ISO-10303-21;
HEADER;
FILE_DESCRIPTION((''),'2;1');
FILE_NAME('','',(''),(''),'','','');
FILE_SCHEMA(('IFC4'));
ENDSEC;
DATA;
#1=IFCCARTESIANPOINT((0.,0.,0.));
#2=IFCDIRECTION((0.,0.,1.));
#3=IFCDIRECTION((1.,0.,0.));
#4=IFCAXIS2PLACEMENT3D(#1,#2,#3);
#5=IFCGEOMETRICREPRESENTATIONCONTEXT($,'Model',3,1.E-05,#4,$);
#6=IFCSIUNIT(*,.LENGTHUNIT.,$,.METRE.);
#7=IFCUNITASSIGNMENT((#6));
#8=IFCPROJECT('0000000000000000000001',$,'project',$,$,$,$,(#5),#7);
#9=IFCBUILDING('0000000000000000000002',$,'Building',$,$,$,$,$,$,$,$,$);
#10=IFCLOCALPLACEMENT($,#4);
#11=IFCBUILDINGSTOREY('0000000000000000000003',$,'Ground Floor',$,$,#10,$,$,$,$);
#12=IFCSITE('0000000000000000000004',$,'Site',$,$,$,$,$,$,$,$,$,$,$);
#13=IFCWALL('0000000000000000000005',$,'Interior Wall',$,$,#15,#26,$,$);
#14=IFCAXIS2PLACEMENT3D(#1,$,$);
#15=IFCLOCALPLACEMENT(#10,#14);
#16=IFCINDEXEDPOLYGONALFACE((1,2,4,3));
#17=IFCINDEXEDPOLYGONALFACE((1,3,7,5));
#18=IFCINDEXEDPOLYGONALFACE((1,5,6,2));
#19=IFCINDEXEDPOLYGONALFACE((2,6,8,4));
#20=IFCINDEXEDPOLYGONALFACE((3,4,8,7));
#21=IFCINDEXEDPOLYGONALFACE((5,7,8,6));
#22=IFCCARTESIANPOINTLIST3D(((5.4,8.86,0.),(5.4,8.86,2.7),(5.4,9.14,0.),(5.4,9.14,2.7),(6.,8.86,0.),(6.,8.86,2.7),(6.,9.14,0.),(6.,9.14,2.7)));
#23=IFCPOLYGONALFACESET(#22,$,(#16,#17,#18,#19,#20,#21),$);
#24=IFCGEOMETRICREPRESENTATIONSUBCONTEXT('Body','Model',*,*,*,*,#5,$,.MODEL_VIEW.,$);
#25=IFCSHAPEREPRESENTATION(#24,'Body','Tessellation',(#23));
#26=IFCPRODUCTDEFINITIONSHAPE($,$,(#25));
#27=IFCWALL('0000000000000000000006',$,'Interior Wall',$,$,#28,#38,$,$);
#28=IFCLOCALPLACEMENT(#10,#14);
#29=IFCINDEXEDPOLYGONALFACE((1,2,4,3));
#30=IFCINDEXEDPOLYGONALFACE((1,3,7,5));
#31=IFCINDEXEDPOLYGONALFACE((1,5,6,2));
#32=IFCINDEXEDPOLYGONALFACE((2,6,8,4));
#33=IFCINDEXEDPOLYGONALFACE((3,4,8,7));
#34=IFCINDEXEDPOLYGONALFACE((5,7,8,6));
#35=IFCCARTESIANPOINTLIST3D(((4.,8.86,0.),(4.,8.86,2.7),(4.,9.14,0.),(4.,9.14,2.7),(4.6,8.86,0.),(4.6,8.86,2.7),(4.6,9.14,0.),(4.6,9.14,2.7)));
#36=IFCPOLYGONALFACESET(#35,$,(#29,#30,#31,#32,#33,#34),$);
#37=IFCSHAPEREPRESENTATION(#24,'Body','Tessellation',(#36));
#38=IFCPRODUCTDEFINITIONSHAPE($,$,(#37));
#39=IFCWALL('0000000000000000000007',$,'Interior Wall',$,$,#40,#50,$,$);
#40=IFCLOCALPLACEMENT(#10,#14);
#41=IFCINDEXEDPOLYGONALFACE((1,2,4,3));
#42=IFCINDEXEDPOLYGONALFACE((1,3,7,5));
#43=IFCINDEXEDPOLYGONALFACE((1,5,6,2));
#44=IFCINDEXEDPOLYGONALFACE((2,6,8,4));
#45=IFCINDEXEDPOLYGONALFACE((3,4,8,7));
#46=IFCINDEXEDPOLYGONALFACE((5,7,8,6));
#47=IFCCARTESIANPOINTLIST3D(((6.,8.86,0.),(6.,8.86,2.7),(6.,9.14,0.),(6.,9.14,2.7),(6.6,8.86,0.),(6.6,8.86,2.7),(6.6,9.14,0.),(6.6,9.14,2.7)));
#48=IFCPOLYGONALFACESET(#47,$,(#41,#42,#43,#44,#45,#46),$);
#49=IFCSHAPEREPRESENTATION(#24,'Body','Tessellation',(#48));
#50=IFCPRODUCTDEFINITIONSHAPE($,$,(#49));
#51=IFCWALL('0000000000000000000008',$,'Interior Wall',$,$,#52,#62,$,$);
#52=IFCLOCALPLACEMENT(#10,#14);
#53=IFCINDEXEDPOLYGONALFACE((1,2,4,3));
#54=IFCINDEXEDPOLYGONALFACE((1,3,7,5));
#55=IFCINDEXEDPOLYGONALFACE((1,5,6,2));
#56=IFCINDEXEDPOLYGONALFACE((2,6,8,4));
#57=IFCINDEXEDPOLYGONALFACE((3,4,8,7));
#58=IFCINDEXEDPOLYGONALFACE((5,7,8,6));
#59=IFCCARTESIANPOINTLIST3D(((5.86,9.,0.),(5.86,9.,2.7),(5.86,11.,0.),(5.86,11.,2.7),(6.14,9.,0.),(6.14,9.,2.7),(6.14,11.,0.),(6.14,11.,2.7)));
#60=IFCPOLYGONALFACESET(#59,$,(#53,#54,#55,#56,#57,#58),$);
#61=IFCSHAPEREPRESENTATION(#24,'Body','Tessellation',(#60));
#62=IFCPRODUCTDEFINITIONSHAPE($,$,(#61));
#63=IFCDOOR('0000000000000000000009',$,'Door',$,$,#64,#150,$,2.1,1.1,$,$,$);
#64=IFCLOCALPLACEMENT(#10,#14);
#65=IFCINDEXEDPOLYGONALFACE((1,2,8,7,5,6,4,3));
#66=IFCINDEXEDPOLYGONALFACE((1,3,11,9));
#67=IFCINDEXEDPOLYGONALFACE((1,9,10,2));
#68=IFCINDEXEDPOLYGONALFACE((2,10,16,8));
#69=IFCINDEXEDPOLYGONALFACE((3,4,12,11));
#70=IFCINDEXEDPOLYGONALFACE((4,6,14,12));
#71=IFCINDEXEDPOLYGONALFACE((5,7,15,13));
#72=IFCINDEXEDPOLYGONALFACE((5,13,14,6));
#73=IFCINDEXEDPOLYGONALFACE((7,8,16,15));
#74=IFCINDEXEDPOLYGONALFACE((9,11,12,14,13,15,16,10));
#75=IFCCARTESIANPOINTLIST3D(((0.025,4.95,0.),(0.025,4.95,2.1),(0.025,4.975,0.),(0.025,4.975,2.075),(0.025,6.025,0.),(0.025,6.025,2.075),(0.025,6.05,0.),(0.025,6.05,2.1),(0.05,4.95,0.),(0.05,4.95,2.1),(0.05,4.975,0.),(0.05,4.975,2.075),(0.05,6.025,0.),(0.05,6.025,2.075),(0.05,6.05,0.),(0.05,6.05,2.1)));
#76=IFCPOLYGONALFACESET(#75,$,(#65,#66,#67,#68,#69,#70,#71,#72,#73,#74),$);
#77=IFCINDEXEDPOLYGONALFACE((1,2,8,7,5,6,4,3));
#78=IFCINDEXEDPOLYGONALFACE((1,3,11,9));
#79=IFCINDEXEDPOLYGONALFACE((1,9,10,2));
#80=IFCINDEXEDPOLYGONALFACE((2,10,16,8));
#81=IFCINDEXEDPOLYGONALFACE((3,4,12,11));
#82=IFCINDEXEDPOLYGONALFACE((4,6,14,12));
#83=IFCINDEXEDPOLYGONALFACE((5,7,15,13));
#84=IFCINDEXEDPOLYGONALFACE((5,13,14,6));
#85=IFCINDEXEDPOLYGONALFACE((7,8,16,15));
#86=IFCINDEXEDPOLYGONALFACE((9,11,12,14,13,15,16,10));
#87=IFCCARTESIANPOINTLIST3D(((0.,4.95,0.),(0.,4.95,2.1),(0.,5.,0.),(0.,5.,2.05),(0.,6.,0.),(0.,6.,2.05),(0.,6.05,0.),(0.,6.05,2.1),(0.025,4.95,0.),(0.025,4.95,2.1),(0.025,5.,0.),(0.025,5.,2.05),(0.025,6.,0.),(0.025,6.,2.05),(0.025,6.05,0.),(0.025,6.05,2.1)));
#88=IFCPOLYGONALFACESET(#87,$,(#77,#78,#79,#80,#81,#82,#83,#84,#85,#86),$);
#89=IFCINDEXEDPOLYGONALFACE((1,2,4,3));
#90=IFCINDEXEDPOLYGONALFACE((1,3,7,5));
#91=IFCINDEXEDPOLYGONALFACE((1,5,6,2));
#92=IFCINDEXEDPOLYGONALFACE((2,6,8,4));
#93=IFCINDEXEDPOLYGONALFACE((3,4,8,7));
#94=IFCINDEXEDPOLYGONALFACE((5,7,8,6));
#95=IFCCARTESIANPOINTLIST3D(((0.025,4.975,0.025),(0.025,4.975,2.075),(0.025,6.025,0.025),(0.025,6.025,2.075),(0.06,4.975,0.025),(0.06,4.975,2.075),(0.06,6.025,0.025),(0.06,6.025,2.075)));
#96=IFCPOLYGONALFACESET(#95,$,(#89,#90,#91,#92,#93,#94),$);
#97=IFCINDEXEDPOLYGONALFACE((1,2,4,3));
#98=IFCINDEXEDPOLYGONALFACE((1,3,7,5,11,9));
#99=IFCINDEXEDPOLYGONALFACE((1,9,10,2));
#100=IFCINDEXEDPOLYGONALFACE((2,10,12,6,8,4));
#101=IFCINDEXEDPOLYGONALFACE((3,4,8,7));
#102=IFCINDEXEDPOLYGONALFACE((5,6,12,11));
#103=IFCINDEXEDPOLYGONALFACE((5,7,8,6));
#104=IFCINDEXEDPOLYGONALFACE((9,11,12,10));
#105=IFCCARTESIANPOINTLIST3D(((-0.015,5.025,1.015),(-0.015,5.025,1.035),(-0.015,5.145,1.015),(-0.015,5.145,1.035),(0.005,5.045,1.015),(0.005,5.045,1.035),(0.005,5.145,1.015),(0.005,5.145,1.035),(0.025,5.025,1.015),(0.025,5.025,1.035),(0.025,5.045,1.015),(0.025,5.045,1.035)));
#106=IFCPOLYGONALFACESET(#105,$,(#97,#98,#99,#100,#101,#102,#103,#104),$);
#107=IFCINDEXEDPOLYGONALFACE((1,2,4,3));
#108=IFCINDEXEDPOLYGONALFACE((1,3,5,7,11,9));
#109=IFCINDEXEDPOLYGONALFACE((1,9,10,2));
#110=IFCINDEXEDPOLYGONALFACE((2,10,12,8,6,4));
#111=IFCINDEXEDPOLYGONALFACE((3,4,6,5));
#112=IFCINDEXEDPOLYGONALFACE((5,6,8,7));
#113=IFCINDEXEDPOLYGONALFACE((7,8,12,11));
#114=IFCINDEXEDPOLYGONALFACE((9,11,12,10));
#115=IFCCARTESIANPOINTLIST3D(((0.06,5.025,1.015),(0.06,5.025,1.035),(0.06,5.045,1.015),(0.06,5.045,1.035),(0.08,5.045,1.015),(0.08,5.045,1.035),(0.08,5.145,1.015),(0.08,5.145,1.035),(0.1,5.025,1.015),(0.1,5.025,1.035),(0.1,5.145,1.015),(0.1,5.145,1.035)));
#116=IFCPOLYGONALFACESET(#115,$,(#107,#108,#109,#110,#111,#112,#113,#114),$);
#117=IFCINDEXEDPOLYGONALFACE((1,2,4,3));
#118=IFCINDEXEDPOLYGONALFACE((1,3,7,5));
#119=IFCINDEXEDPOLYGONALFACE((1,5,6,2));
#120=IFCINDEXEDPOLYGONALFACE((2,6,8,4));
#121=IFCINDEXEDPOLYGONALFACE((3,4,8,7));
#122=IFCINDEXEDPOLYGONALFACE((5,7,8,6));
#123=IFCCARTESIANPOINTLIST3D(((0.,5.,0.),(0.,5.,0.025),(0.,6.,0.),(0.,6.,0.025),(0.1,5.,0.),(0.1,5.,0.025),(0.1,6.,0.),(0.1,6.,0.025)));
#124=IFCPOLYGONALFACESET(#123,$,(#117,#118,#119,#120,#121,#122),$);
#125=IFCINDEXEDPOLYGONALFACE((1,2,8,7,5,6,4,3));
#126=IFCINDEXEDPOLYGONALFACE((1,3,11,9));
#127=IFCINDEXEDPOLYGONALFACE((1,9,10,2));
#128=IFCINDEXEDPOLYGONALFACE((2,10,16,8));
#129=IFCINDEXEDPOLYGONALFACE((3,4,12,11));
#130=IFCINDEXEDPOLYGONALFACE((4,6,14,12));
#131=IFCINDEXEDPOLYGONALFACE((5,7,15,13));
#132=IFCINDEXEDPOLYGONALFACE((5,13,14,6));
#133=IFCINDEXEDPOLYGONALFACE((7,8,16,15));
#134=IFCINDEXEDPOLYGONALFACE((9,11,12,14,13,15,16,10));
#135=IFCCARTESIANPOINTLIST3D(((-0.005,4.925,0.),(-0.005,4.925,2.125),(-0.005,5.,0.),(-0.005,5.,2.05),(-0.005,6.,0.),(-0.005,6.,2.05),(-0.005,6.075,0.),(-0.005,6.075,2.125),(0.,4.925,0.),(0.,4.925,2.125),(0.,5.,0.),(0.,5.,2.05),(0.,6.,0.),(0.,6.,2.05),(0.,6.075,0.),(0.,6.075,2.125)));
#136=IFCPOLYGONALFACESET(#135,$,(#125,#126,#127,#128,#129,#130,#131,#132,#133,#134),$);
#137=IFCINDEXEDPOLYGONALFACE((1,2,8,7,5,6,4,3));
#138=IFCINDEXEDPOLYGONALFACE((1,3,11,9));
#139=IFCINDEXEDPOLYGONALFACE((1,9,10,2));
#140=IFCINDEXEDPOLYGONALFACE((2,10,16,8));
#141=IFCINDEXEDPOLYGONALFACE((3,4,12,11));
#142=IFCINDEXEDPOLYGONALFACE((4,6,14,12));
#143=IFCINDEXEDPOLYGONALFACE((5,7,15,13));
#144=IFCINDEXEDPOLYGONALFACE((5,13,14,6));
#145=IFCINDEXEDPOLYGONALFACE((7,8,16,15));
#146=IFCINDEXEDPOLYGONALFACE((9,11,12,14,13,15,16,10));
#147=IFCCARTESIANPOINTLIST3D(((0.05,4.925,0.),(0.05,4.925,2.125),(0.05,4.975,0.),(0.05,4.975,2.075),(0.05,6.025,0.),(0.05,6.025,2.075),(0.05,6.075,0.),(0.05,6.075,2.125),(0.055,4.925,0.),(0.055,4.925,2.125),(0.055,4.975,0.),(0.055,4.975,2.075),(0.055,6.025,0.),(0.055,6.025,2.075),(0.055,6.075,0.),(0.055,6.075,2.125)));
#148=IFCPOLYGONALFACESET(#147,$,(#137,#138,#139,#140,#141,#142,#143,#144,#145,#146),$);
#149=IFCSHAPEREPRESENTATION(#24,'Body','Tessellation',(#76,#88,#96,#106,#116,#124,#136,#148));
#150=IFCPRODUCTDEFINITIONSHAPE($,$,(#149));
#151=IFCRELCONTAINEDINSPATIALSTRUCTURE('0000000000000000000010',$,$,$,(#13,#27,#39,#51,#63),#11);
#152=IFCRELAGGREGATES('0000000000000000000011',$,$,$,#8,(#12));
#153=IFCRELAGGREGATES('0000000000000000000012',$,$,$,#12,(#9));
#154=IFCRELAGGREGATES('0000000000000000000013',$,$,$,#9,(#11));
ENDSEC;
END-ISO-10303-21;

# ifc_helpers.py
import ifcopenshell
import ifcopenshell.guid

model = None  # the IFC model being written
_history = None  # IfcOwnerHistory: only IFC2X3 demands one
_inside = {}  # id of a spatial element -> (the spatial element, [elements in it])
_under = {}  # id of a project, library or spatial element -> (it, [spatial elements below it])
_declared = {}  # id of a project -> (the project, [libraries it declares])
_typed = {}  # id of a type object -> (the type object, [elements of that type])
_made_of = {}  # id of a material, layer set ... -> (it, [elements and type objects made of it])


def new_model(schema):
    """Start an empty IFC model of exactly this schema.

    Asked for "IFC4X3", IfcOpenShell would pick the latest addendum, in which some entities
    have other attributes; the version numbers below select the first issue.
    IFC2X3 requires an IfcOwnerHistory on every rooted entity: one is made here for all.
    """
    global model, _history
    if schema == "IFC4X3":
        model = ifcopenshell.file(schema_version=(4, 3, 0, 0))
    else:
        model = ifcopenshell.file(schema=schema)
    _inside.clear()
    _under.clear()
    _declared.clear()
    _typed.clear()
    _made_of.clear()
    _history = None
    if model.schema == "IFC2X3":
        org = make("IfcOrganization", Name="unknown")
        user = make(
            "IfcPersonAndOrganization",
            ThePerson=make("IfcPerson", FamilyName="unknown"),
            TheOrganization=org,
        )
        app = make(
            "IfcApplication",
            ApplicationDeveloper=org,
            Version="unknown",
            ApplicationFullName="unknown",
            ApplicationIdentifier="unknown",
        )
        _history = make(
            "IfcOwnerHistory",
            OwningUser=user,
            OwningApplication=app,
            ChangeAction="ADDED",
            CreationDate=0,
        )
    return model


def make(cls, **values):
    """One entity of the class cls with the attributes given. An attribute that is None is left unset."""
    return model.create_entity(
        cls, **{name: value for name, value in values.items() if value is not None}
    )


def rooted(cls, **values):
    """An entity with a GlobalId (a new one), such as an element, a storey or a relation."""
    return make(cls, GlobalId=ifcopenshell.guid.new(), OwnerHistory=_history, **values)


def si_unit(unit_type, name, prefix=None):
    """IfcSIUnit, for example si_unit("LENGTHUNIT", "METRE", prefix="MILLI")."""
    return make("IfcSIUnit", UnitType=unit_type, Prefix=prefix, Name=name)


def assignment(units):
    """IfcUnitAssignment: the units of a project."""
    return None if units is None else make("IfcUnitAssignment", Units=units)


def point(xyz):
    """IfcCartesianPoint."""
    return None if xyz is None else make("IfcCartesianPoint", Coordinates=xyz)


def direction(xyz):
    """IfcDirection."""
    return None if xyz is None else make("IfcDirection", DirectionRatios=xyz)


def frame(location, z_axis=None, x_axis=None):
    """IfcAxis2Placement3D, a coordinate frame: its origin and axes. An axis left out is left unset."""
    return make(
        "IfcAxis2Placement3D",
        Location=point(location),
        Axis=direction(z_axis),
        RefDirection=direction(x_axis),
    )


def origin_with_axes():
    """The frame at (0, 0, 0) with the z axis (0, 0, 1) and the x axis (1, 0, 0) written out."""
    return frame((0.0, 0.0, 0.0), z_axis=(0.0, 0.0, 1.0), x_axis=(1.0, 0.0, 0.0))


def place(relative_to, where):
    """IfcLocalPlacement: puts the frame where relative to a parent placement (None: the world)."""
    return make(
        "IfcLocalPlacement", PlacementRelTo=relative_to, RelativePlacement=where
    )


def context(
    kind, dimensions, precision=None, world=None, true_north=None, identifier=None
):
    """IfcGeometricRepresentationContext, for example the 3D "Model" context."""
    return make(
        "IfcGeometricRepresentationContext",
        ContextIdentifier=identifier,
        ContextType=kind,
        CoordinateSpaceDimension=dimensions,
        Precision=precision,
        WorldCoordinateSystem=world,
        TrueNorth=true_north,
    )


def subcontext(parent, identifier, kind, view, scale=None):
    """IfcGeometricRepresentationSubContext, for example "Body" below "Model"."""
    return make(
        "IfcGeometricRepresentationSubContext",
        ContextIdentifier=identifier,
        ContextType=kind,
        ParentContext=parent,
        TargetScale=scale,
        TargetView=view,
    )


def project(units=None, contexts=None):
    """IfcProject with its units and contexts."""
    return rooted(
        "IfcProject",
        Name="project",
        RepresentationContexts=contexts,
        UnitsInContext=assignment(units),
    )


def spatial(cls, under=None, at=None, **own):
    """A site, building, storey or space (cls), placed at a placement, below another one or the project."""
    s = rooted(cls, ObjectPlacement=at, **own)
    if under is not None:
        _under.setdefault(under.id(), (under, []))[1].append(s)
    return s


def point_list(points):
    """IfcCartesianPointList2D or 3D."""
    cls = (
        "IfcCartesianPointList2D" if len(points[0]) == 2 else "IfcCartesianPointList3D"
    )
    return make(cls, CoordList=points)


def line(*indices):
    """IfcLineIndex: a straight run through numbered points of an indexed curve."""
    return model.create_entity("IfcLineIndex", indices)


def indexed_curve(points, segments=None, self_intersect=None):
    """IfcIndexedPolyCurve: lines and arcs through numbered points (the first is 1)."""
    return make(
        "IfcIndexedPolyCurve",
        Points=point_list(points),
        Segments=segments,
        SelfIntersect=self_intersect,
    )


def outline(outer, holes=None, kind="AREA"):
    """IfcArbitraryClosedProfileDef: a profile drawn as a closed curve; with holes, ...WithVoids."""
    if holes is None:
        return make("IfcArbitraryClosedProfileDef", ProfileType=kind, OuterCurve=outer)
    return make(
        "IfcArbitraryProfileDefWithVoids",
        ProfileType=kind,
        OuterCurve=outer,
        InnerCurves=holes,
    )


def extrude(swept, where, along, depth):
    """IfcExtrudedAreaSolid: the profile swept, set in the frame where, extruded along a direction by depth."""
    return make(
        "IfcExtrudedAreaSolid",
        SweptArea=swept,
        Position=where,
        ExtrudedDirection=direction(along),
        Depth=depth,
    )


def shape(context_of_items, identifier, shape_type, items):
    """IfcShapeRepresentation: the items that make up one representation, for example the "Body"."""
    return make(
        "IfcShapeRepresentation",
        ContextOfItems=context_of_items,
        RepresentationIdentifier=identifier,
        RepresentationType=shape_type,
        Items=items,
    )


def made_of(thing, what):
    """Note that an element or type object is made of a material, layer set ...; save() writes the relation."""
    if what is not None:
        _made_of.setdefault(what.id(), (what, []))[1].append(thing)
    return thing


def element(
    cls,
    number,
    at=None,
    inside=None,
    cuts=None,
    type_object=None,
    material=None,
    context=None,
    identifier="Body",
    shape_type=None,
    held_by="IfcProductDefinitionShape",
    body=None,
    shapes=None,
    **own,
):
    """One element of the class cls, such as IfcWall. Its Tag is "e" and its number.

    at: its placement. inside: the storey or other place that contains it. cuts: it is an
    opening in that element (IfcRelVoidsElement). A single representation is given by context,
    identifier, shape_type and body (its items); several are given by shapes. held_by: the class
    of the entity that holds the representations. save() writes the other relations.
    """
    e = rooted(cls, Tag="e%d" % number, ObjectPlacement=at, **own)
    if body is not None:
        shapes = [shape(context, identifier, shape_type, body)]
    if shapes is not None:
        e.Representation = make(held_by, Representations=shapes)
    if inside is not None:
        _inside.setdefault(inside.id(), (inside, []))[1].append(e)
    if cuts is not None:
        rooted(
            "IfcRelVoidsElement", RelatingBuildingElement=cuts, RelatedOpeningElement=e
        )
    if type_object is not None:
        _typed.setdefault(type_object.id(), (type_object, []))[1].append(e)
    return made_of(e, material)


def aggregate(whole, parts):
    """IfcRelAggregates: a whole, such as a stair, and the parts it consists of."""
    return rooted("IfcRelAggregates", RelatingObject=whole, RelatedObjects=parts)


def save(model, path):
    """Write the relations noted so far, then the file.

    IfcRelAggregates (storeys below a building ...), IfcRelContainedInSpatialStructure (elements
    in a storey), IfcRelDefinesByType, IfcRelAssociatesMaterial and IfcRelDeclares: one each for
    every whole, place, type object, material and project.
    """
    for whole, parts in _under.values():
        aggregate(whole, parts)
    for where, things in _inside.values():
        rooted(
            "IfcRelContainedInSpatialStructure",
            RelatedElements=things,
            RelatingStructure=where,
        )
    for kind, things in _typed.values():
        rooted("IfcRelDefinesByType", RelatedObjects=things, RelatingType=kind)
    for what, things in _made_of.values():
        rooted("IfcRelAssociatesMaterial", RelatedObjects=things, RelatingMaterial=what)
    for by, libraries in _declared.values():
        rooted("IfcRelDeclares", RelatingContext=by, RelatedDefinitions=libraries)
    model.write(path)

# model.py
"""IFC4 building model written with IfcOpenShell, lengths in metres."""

from ifc_helpers import new_model, si_unit, frame, origin_with_axes, place, context, subcontext, project, spatial, line, indexed_curve, outline, extrude, element, save


model = new_model("IFC4")

# Units and contexts
model_context = context("Model", 3, precision=1e-05, world=origin_with_axes())
body_context = subcontext(model_context, "Body", "Model", "MODEL_VIEW")
ifc_project = project(units=[si_unit("LENGTHUNIT", "METRE")], contexts=[model_context])

# Site, building, storey
site = spatial("IfcSite", under=ifc_project, Name="Site")
building = spatial("IfcBuilding", under=site, Name="Building")
storey_placement = place(None, origin_with_axes())
storey = spatial("IfcBuildingStorey", under=building, at=storey_placement, Name="Ground Floor")

# Walls
for number, where, z_axis, x_axis, name in (
    (1, (6.0, 9.0, 0.0), (0.0, 0.0, 1.0), (-1.0, 0.0, 0.0), "Interior Wall"),
    (2, (4.6, 9.0, 0.0), (0.0, 0.0, 1.0), (-1.0, 0.0, 0.0), "Interior Wall"),
    (3, (6.6, 9.0, 0.0), (0.0, 0.0, 1.0), (-1.0, 0.0, 0.0), "Interior Wall"),
):
    element("IfcWall", number, at=place(storey_placement, frame(where, z_axis=z_axis, x_axis=x_axis)), inside=storey, Name=name, context=body_context, shape_type="SweptSolid", body=[
        extrude(outline(indexed_curve([(0.0, 0.0), (0.0, 0.28), (0.6, 0.28), (0.6, 0.0), (0.0, 0.0)], self_intersect=False)), frame((0.0, -0.14, 0.0), z_axis=(0.0, 0.0, 1.0), x_axis=(1.0, 0.0, 0.0)), (0.0, 0.0, 1.0), 2.7),
    ])
wall_1_placement = place(storey_placement, frame((6.0, 9.0, 0.0), z_axis=(0.0, 0.0, 1.0), x_axis=(0.0, 1.0, 0.0)))
element("IfcWall", 4, at=wall_1_placement, inside=storey, Name="Interior Wall", context=body_context, shape_type="SweptSolid", body=[
    extrude(outline(indexed_curve([(0.0, 0.0), (0.0, 0.28), (2.0, 0.28), (2.0, 0.0), (0.0, 0.0)], self_intersect=False)), frame((0.0, -0.14, 0.0), z_axis=(0.0, 0.0, 1.0), x_axis=(1.0, 0.0, 0.0)), (0.0, 0.0, 1.0), 2.7),
])

# Door
door_1_placement = place(storey_placement, frame((0.0, 6.05, 0.0), z_axis=(0.0, 0.0, 1.0), x_axis=(0.0, -1.0, 0.0)))
element("IfcDoor", 5, at=door_1_placement, inside=storey, Name="Door", OverallHeight=2.1, OverallWidth=1.1, context=body_context, shape_type="SweptSolid", body=[
    extrude(outline(indexed_curve([(0.0, 0.0), (0.0, 2.1), (1.1, 2.1), (1.1, 0.0), (1.075, 0.0), (1.075, 2.075), (0.025, 2.075), (0.025, 0.0)], segments=[line(1, 2, 3, 4, 5, 6, 7, 8, 1)])), frame((0.0, 0.025, 0.0), z_axis=(0.0, -1.0, 0.0), x_axis=(1.0, 0.0, 0.0)), (0.0, 0.0, -1.0), 0.025),
    extrude(outline(indexed_curve([(0.0, 0.0), (0.0, 2.1), (1.1, 2.1), (1.1, 0.0), (1.05, 0.0), (1.05, 2.05), (0.05, 2.05), (0.05, 0.0)], segments=[line(1, 2, 3, 4, 5, 6, 7, 8, 1)])), frame((0.0, 0.0, 0.0), z_axis=(0.0, -1.0, 0.0), x_axis=(1.0, 0.0, 0.0)), (0.0, 0.0, -1.0), 0.025),
    extrude(outline(indexed_curve([(0.0, 0.0), (1.05, 0.0), (1.05, 0.035), (0.0, 0.035)], segments=[line(1, 2, 3, 4, 1)])), frame((0.025, 0.025, 0.025), z_axis=(0.0, 0.0, 1.0), x_axis=(1.0, 0.0, 0.0)), (0.0, 0.0, 1.0), 2.05),
    extrude(outline(indexed_curve([(0.0, 0.0), (0.0, -0.04), (-0.12, -0.04), (-0.12, -0.02), (-0.02, -0.02), (-0.02, 0.0)], segments=[line(1, 2, 3, 4, 5, 6, 1)])), frame((1.025, 0.025, 1.015), z_axis=(0.0, 0.0, 1.0), x_axis=(1.0, 0.0, 0.0)), (0.0, 0.0, 1.0), 0.02),
    extrude(outline(indexed_curve([(0.0, 0.0), (0.0, 0.04), (-0.12, 0.04), (-0.12, 0.02), (-0.02, 0.02), (-0.02, 0.0)], segments=[line(1, 2, 3, 4, 5, 6, 1)])), frame((1.025, 0.06, 1.015), z_axis=(0.0, 0.0, 1.0), x_axis=(1.0, 0.0, 0.0)), (0.0, 0.0, 1.0), 0.02),
    extrude(outline(indexed_curve([(0.0, 0.0), (1.0, 0.0), (1.0, 0.1), (0.0, 0.1)], segments=[line(1, 2, 3, 4, 1)])), frame((0.05, 0.0, 0.0), z_axis=(0.0, 0.0, 1.0), x_axis=(1.0, 0.0, 0.0)), (0.0, 0.0, 1.0), 0.025),
    extrude(outline(indexed_curve([(0.0, 0.0), (0.0, 2.125), (1.15, 2.125), (1.15, 0.0), (1.075, 0.0), (1.075, 2.05), (0.075, 2.05), (0.075, 0.0)], segments=[line(1, 2, 3, 4, 5, 6, 7, 8, 1)])), frame((-0.025, -0.005, 0.0), z_axis=(0.0, -1.0, 0.0), x_axis=(1.0, 0.0, 0.0)), (0.0, 0.0, -1.0), 0.005),
    extrude(outline(indexed_curve([(0.0, 0.0), (0.0, 2.125), (1.15, 2.125), (1.15, 0.0), (1.1, 0.0), (1.1, 2.075), (0.05, 2.075), (0.05, 0.0)], segments=[line(1, 2, 3, 4, 5, 6, 7, 8, 1)])), frame((-0.025, 0.05, 0.0), z_axis=(0.0, -1.0, 0.0), x_axis=(1.0, 0.0, 0.0)), (0.0, 0.0, -1.0), 0.005),
])

save(model, "model.ifc")
